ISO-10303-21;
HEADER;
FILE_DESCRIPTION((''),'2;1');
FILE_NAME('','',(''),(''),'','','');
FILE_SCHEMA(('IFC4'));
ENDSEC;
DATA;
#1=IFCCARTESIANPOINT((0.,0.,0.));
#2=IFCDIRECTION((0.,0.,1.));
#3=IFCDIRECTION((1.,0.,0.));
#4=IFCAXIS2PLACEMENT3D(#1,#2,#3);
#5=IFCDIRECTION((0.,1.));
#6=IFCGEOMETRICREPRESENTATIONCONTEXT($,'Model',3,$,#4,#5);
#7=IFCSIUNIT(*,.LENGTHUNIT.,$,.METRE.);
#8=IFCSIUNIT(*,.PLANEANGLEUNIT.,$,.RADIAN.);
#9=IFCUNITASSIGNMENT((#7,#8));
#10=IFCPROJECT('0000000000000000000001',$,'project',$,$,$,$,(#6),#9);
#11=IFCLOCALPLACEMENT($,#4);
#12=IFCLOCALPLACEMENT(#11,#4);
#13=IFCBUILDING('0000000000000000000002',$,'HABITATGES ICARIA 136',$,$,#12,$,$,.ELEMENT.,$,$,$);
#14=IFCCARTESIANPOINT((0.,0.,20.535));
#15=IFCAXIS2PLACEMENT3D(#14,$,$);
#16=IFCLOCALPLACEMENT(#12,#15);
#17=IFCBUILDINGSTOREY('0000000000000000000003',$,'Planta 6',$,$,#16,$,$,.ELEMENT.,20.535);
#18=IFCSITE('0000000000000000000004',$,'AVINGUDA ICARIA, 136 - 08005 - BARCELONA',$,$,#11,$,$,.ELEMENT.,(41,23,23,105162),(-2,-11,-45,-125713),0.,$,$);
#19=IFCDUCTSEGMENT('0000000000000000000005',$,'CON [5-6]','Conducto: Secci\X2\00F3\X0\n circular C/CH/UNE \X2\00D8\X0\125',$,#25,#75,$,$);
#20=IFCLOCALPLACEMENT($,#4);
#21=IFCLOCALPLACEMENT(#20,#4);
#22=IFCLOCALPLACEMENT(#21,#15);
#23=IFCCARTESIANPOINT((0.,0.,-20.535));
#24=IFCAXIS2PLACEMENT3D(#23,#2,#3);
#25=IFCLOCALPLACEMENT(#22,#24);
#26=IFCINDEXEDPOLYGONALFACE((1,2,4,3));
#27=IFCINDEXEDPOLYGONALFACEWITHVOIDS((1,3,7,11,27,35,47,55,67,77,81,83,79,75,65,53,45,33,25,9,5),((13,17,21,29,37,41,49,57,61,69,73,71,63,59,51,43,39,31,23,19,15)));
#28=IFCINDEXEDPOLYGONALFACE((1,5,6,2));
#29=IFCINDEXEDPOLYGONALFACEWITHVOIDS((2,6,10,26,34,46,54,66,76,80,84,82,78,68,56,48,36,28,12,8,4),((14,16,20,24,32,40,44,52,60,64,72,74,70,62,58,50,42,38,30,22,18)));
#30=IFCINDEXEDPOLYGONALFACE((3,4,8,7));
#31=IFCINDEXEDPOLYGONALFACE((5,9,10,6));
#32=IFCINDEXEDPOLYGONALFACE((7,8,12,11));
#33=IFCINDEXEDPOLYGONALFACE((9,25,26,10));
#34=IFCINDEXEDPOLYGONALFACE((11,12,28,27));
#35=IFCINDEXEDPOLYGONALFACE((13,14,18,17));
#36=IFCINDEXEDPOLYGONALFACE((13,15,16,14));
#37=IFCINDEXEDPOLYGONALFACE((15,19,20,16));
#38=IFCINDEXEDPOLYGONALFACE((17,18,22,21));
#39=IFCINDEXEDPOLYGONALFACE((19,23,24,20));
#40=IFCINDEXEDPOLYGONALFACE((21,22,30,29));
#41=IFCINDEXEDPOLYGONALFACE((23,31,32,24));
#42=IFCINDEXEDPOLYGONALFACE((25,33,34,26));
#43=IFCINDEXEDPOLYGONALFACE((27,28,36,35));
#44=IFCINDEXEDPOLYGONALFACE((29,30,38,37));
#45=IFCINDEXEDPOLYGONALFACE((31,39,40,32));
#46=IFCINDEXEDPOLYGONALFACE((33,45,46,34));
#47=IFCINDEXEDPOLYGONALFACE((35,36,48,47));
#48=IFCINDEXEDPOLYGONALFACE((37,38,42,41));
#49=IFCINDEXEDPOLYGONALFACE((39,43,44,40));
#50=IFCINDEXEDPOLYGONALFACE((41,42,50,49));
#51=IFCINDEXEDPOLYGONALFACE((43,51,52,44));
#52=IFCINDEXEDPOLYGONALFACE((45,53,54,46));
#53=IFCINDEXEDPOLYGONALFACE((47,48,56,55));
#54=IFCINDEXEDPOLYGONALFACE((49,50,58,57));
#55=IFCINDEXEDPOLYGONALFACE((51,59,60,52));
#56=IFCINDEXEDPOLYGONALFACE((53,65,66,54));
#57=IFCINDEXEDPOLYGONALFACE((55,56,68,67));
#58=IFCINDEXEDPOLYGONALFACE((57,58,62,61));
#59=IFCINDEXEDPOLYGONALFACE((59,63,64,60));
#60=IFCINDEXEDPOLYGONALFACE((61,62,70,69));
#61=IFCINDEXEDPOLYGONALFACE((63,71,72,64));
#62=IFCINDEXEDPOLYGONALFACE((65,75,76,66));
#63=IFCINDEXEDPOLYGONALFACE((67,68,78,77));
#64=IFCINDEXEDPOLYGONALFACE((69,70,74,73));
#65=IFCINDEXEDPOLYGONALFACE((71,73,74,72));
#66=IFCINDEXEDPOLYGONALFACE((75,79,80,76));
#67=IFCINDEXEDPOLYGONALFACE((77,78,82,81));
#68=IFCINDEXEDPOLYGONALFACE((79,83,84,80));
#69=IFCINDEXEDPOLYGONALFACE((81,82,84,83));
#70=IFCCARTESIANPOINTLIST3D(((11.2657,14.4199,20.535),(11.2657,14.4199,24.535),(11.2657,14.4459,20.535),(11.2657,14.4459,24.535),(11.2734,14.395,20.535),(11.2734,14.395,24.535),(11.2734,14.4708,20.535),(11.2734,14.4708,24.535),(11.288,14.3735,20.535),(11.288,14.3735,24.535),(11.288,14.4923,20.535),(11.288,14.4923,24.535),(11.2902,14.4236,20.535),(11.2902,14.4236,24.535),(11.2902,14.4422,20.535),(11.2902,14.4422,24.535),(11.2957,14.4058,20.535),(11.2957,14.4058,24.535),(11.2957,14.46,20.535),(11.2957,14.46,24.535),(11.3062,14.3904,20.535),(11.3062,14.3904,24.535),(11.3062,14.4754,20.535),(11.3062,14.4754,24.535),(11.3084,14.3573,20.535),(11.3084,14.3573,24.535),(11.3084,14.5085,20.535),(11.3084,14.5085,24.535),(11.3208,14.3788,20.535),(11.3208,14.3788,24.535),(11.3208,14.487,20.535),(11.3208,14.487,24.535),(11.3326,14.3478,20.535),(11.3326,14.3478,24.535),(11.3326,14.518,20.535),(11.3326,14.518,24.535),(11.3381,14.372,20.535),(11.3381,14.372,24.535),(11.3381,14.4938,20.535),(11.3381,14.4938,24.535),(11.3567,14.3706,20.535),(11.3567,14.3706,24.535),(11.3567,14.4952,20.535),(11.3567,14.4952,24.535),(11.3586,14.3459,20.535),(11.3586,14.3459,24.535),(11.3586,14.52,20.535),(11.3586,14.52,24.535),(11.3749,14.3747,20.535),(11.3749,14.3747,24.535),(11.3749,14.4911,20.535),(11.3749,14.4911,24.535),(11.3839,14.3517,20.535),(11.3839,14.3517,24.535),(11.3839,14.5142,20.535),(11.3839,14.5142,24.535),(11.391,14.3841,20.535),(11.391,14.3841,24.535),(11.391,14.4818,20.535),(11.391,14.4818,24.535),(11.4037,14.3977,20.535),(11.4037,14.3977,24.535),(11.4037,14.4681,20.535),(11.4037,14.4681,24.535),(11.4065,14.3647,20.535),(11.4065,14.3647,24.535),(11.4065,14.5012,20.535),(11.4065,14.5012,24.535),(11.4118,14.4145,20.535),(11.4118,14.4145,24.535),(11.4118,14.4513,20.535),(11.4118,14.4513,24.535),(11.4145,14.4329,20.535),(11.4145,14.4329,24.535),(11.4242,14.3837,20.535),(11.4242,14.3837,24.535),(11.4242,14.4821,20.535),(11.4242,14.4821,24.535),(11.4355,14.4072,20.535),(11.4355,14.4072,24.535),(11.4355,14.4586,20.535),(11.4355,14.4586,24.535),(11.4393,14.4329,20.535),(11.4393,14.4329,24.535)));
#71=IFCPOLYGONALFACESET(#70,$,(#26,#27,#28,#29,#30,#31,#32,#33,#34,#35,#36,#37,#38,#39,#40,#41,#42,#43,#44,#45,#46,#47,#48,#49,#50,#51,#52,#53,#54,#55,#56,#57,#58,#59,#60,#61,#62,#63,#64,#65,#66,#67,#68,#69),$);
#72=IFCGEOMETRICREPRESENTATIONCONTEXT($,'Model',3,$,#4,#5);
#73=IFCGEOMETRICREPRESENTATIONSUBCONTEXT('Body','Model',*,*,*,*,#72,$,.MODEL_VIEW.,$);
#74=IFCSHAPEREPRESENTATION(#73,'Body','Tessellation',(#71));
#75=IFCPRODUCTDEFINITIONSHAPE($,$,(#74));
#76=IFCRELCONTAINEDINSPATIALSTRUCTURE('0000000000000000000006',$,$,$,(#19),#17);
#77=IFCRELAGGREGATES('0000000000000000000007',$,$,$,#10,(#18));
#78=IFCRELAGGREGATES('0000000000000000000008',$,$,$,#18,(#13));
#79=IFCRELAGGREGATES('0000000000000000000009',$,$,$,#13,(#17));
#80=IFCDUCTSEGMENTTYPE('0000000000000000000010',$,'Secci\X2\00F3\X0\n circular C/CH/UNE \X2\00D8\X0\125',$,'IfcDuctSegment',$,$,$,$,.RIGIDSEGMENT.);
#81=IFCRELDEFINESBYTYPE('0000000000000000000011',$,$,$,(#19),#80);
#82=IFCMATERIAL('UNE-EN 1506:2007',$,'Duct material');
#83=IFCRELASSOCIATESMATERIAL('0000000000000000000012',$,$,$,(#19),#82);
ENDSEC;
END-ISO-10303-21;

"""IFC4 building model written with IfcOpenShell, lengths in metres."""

from ifc_helpers import new_model, si_unit, direction, frame, origin_with_axes, origin_2d_with_axis, place, context, subcontext, project, spatial, hollow_circle, extrude, material, type_object, element, save


model = new_model("IFC4")

# Units and contexts
model_context_1 = context("Model", 3, world=origin_with_axes(), true_north=direction((0.0, 1.0)))
model_context_2 = context("Model", 3, world=origin_with_axes(), true_north=direction((0.0, 1.0)))
body_context_1 = subcontext(model_context_2, "Body", "Model", "MODEL_VIEW")
ifc_project = project(units=[si_unit("LENGTHUNIT", "METRE"), si_unit("PLANEANGLEUNIT", "RADIAN")], contexts=[model_context_1])

# Site, building, storey
site_placement = place(None, origin_with_axes())
site = spatial("IfcSite", under=ifc_project, at=site_placement, Name="AVINGUDA ICARIA, 136 - 08005 - BARCELONA", CompositionType="ELEMENT", RefLatitude=(41, 23, 23, 105162), RefLongitude=(-2, -11, -45, -125713), RefElevation=0.0)
building_placement = place(site_placement, origin_with_axes())
building = spatial("IfcBuilding", under=site, at=building_placement, Name="HABITATGES ICARIA 136", CompositionType="ELEMENT")
storey_placement = place(building_placement, frame((0.0, 0.0, 20.535)))
storey = spatial("IfcBuildingStorey", under=building, at=storey_placement, Name="Planta 6", CompositionType="ELEMENT", Elevation=20.535)

# Duct segment
ifc_material = material(Name="UNE-EN 1506:2007", Category="Duct material")
duct_segment_type = type_object("IfcDuctSegmentType", Name="Sección circular C/CH/UNE Ø125", ApplicableOccurrence="IfcDuctSegment", PredefinedType="RIGIDSEGMENT")
placement_1 = place(None, origin_with_axes())
placement_2 = place(placement_1, origin_with_axes())
placement_3 = place(placement_2, frame((0.0, 0.0, 20.535)))
duct_segment_placement = place(placement_3, frame((0.0, 0.0, -20.535), z_axis=(0.0, 0.0, 1.0), x_axis=(1.0, 0.0, 0.0)))
element("IfcDuctSegment", 1, at=duct_segment_placement, inside=storey, type_object=duct_segment_type, material=ifc_material, Name="CON [5-6]", Description="Conducto: Sección circular C/CH/UNE Ø125", context=body_context_1, shape_type="SweptSolid", body=[
    extrude(hollow_circle(Radius=0.0873, WallThickness=0.0248, at=origin_2d_with_axis()), frame((11.352, 14.4329, 24.535), z_axis=(0.0, 0.0, -1.0), x_axis=(1.0, 0.0, 0.0)), (0.0, 0.0, 1.0), 4.0),
])

save(model, "model.ifc")
